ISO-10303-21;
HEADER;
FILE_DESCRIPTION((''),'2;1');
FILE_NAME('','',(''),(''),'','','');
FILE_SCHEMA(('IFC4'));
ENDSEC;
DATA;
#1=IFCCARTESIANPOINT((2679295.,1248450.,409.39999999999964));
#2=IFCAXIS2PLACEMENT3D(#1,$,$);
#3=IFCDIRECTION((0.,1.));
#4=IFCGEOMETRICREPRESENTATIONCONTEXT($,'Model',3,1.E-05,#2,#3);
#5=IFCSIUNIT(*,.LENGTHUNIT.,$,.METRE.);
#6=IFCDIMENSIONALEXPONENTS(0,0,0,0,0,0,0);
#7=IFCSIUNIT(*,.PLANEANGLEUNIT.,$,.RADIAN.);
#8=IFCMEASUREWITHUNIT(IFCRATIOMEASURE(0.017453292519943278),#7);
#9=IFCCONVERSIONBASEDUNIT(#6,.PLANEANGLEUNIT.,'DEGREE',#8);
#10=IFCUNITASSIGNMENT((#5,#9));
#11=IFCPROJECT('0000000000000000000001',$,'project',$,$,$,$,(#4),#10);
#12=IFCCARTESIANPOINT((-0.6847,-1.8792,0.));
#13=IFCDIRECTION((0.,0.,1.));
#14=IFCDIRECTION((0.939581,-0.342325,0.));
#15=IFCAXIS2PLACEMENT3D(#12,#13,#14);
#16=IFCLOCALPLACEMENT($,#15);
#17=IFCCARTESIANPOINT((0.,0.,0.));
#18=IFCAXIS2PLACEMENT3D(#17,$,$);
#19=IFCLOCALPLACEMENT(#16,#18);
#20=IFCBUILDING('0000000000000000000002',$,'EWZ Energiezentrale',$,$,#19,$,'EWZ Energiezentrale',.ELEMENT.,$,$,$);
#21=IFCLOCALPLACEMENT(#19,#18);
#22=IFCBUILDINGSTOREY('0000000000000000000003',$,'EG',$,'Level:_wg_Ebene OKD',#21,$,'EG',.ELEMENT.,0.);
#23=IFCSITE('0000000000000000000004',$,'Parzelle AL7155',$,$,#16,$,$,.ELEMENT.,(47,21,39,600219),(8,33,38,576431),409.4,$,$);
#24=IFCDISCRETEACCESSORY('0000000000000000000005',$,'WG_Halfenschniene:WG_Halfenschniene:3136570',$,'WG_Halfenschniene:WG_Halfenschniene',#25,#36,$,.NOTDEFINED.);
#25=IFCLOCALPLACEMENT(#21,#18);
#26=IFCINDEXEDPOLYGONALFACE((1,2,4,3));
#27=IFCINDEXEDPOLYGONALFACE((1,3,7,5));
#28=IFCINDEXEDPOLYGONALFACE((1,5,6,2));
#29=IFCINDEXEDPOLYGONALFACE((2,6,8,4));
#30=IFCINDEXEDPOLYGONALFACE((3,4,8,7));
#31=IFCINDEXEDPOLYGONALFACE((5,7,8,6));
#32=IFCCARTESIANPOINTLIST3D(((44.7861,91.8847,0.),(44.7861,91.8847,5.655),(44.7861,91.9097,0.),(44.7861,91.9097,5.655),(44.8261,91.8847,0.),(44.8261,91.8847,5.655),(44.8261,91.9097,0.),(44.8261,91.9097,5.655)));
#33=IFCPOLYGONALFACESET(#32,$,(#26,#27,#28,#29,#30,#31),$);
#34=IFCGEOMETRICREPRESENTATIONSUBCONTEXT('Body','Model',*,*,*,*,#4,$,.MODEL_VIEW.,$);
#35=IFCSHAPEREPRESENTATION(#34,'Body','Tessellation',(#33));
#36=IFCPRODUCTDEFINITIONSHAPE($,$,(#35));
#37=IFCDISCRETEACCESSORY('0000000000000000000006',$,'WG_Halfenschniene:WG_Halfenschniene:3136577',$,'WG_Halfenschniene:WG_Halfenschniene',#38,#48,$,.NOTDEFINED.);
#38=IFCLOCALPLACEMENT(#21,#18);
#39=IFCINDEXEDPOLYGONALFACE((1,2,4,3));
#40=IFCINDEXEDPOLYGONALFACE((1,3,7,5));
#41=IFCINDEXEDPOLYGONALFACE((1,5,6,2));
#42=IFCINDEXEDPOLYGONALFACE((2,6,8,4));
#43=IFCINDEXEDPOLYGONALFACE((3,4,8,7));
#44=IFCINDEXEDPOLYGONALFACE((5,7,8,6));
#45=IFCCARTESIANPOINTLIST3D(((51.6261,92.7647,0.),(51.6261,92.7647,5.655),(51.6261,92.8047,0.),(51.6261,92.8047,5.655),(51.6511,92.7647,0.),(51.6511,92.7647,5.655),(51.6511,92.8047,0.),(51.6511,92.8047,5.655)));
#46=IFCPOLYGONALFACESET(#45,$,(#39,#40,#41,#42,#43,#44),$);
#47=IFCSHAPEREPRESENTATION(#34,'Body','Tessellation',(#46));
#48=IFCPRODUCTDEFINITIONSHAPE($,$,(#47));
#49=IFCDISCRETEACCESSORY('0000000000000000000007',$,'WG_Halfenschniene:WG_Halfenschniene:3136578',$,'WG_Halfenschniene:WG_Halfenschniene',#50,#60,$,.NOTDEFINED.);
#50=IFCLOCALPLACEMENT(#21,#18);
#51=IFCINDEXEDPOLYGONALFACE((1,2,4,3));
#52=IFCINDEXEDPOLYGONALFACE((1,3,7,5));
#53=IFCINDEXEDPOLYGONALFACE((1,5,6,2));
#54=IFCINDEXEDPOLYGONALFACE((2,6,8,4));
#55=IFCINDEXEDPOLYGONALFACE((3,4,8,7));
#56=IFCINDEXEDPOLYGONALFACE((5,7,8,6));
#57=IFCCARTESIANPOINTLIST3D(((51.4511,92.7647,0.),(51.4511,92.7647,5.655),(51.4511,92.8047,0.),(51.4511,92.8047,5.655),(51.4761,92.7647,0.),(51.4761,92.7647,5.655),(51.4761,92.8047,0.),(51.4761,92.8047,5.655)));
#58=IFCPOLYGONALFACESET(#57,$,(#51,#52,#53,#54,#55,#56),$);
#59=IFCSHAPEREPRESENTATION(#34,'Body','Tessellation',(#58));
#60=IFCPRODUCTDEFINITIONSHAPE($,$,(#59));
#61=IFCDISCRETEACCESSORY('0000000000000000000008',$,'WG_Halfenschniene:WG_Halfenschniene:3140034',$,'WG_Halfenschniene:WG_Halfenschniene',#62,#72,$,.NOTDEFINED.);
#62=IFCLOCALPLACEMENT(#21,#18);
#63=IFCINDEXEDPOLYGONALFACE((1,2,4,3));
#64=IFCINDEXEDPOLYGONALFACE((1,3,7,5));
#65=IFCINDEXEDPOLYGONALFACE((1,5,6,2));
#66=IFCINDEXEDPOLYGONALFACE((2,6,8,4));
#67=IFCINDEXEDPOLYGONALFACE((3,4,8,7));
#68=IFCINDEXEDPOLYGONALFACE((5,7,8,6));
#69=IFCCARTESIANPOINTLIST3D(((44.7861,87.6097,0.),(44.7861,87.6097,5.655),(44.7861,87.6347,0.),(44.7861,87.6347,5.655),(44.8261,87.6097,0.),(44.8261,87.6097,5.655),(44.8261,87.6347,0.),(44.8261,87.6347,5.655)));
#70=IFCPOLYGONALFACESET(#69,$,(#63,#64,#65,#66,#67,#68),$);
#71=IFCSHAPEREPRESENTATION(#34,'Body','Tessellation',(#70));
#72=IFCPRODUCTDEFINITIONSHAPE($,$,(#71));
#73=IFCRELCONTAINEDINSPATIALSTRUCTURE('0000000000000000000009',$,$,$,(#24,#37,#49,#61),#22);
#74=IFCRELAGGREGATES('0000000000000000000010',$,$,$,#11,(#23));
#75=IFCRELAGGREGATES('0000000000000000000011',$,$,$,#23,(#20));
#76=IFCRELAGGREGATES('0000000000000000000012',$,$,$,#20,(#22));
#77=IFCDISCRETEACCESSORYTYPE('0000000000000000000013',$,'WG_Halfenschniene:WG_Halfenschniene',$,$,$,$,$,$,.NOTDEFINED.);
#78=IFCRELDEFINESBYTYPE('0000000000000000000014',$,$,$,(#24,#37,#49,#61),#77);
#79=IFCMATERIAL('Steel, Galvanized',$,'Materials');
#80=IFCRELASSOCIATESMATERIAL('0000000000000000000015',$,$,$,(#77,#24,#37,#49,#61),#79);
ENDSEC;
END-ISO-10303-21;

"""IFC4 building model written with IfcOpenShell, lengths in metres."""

from ifc_helpers import new_model, entity, si_unit, converted_unit, direction, frame, origin, place, context, subcontext, project, spatial, indexed_curve, outline, extrude, source, transform, mapped, material, type_object, element, save


model = new_model("IFC4")

# Units and contexts
model_context = context("Model", 3, precision=1e-05, world=frame((2679295.0, 1248450.0, 409.39999999999964)), true_north=direction((0.0, 1.0)))
body_context = subcontext(model_context, "Body", "Model", "MODEL_VIEW")
ifc_project = project(units=[si_unit("LENGTHUNIT", "METRE"), converted_unit("PLANEANGLEUNIT", "DEGREE", entity("IfcRatioMeasure", 0.017453292519943278), si_unit("PLANEANGLEUNIT", "RADIAN"), dimensions=[0, 0, 0, 0, 0, 0, 0])], contexts=[model_context])

# Site, building, storey
site_placement = place(None, frame((-0.6847, -1.8792, 0.0), z_axis=(0.0, 0.0, 1.0), x_axis=(0.939581, -0.342325, 0.0)))
site = spatial("IfcSite", under=ifc_project, at=site_placement, Name="Parzelle AL7155", CompositionType="ELEMENT", RefLatitude=(47, 21, 39, 600219), RefLongitude=(8, 33, 38, 576431), RefElevation=409.4)
building_placement = place(site_placement, origin())
building = spatial("IfcBuilding", under=site, at=building_placement, Name="EWZ Energiezentrale", LongName="EWZ Energiezentrale", CompositionType="ELEMENT")
storey_placement = place(building_placement, origin())
storey = spatial("IfcBuildingStorey", under=building, at=storey_placement, Name="EG", ObjectType="Level:_wg_Ebene OKD", LongName="EG", CompositionType="ELEMENT", Elevation=0.0)

# Discrete accessories
ifc_material_1 = material(Name="Steel, Galvanized", Category="Materials")
discrete_accessory_type = type_object("IfcDiscreteAccessoryType", Name="WG_Halfenschniene:WG_Halfenschniene", PredefinedType="NOTDEFINED", material=ifc_material_1)
shared_shape_1 = source(origin(), body_context, "Body", "SweptSolid", [
    extrude(outline(indexed_curve([(-2.8275, -0.02), (2.8275, -0.02), (2.8275, 0.02), (-2.8275, 0.02), (-2.8275, -0.02)], self_intersect=False)), frame((2.8275, 0.0, -0.0125)), (0.0, 0.0, 1.0), 0.025),
])
for number, where, z_axis, x_axis, name in (
    (1, (44.8061, 91.8972, 5.655), (0.0, 1.0, 0.0), (0.0, 0.0, -1.0), "WG_Halfenschniene:WG_Halfenschniene:3136570"),
    (2, (51.6386, 92.7847, 5.655), (1.0, 0.0, 0.0), (0.0, 0.0, -1.0), "WG_Halfenschniene:WG_Halfenschniene:3136577"),
    (3, (51.4636, 92.7847, 5.655), (1.0, 0.0, 0.0), (0.0, 0.0, -1.0), "WG_Halfenschniene:WG_Halfenschniene:3136578"),
    (4, (44.8061, 87.6222, 5.655), (0.0, 1.0, 0.0), (0.0, 0.0, -1.0), "WG_Halfenschniene:WG_Halfenschniene:3140034"),
):
    element("IfcDiscreteAccessory", number, at=place(storey_placement, frame(where, z_axis=z_axis, x_axis=x_axis)), inside=storey, type_object=discrete_accessory_type, material=ifc_material_1, Name=name, ObjectType="WG_Halfenschniene:WG_Halfenschniene", PredefinedType="NOTDEFINED", context=body_context, shape_type="MappedRepresentation", body=[
        mapped(shared_shape_1, transform((0.0, 0.0, 0.0), scale=1.0)),
    ])

save(model, "model.ifc")
